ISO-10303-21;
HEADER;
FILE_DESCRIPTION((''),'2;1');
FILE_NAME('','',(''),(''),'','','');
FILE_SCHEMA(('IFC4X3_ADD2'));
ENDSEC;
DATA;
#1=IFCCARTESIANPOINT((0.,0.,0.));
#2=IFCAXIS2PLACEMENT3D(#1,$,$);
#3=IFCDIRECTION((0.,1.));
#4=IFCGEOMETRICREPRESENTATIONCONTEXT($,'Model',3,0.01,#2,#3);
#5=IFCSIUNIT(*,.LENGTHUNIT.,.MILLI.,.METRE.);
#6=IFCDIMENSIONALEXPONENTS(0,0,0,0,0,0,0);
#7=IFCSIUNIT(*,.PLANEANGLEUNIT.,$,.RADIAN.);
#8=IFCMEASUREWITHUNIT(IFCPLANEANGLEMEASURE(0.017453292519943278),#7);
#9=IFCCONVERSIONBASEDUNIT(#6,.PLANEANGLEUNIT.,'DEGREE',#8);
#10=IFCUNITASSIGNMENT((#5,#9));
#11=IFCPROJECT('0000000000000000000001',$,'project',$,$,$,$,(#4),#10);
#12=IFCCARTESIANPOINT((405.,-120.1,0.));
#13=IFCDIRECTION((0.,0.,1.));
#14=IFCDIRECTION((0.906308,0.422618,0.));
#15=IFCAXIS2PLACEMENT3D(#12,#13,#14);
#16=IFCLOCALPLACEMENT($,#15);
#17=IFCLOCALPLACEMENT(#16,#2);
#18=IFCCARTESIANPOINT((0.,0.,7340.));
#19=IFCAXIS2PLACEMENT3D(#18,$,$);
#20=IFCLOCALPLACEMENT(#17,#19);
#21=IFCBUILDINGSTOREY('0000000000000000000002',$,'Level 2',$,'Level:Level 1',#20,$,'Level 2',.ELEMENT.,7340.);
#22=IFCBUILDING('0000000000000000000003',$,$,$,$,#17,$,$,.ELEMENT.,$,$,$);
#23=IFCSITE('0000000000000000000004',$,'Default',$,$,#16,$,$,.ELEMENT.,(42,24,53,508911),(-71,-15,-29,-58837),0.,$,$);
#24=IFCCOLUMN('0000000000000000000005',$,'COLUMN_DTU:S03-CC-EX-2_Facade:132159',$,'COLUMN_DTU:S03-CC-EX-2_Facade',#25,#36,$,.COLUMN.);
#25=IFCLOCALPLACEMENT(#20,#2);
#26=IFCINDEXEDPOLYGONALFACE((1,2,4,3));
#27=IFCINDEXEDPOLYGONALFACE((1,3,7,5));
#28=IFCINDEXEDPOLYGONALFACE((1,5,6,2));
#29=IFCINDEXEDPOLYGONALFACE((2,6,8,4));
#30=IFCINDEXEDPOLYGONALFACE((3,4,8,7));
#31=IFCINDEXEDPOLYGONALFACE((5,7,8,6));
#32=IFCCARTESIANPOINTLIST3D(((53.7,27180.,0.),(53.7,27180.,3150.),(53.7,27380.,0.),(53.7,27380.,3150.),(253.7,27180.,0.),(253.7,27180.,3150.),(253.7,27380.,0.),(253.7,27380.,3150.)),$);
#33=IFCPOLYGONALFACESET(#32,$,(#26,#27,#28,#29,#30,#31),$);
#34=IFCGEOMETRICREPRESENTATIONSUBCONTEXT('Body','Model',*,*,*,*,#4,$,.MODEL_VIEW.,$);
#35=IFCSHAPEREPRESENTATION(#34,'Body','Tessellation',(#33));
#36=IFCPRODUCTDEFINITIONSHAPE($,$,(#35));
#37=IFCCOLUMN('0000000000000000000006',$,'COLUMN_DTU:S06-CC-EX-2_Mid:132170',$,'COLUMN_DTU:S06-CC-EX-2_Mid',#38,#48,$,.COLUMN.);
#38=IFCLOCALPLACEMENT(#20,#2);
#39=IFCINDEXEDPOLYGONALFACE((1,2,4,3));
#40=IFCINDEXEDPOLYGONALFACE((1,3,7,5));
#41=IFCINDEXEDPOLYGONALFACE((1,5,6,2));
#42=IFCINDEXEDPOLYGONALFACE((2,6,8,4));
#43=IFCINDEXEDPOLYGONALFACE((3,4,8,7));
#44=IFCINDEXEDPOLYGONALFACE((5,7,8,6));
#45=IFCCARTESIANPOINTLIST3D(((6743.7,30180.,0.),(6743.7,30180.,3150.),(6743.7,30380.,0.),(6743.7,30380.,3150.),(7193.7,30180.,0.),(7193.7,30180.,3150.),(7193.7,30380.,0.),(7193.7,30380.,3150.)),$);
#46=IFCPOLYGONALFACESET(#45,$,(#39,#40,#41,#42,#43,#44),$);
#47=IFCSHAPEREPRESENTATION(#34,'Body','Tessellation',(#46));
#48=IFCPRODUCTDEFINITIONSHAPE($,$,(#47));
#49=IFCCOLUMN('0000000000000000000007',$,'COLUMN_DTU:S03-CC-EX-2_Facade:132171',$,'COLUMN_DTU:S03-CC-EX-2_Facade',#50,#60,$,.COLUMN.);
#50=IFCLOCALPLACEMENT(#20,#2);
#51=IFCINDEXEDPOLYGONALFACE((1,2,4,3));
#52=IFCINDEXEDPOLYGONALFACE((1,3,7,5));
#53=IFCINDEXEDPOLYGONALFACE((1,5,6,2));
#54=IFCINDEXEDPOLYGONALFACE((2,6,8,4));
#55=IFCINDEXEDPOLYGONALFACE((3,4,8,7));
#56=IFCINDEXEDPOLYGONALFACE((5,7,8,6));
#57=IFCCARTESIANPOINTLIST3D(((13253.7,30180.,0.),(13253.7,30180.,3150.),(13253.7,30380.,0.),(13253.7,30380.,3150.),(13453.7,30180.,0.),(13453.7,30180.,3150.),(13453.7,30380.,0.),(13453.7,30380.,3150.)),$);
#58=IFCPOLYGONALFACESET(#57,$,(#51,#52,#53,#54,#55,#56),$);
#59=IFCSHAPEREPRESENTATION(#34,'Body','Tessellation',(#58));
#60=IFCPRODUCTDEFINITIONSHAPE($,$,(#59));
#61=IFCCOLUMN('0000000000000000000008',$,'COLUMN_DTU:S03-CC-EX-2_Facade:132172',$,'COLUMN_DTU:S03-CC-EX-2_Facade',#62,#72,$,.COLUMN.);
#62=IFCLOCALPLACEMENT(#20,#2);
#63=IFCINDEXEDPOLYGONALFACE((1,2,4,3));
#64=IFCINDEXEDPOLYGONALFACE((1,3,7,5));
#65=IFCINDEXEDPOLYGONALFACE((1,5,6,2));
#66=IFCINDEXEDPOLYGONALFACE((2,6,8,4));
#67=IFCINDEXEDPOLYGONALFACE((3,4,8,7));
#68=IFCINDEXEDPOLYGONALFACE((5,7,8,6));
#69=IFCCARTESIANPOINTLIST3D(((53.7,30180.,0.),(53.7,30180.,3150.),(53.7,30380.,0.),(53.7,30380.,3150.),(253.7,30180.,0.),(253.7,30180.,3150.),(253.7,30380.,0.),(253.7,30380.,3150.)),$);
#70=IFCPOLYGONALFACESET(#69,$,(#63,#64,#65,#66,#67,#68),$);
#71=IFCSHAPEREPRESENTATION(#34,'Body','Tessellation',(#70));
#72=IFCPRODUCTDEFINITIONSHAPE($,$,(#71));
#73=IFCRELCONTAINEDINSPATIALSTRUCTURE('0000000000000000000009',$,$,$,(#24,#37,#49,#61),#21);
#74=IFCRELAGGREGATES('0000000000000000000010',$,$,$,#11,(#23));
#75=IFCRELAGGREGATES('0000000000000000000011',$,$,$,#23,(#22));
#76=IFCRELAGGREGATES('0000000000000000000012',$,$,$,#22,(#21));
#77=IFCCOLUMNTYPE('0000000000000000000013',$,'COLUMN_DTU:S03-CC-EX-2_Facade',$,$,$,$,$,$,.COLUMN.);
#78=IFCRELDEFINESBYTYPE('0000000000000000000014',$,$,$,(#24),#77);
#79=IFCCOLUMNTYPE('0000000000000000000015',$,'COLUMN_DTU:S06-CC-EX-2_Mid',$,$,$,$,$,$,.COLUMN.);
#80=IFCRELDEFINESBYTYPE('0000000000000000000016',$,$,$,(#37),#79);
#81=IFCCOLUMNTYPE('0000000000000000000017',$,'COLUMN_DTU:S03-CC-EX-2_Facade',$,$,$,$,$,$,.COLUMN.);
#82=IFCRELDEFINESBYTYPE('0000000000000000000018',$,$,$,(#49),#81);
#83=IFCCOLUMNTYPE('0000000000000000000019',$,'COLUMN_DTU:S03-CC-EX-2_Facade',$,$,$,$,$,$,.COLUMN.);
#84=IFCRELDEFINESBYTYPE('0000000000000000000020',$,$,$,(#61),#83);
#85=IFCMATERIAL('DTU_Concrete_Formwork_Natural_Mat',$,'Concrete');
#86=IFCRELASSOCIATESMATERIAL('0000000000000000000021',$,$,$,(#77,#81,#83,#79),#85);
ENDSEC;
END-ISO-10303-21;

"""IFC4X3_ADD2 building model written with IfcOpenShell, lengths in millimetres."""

from ifc_helpers import new_model, entity, si_unit, converted_unit, direction, frame, frame_2d, origin, origin_2d_with_axis, place, context, subcontext, project, spatial, rectangle, extrude, source, transform, mapped, material, material_profile, profile_set, type_object, type_shapes, element, save


model = new_model("IFC4X3_ADD2")

# Units and contexts
model_context = context("Model", 3, precision=0.01, world=origin(), true_north=direction((0.0, 1.0)))
body_context = subcontext(model_context, "Body", "Model", "MODEL_VIEW")
ifc_project = project(units=[si_unit("LENGTHUNIT", "METRE", prefix="MILLI"), converted_unit("PLANEANGLEUNIT", "DEGREE", entity("IfcPlaneAngleMeasure", 0.017453292519943278), si_unit("PLANEANGLEUNIT", "RADIAN"), dimensions=[0, 0, 0, 0, 0, 0, 0])], contexts=[model_context])

# Site, building, storey
site_placement = place(None, frame((405.0, -120.1, 0.0), z_axis=(0.0, 0.0, 1.0), x_axis=(0.906308, 0.422618, 0.0)))
site = spatial("IfcSite", under=ifc_project, at=site_placement, Name="Default", CompositionType="ELEMENT", RefLatitude=(42, 24, 53, 508911), RefLongitude=(-71, -15, -29, -58837), RefElevation=0.0)
building_placement = place(site_placement, origin())
building = spatial("IfcBuilding", under=site, at=building_placement, CompositionType="ELEMENT")
storey_placement = place(building_placement, frame((0.0, 0.0, 7340.0)))
storey = spatial("IfcBuildingStorey", under=building, at=storey_placement, Name="Level 2", ObjectType="Level:Level 1", LongName="Level 2", CompositionType="ELEMENT", Elevation=7340.0)

# Columns
ifc_material = material(Name="DTU_Concrete_Formwork_Natural_Mat", Category="Concrete")
ifc_material_profile_1 = material_profile(ifc_material, rectangle(XDim=200.0, YDim=200.0, at=frame_2d((0.0, 0.0), x_axis=(1.0, 0.0))), Name="S03-CC-EX-2_Facade")
ifc_profile_set_1 = profile_set([ifc_material_profile_1], Name="S03-CC-EX-2_Facade")
ifc_material_profile_2 = material_profile(ifc_material, rectangle(XDim=200.0, YDim=450.0, at=origin_2d_with_axis()), Name="S06-CC-EX-2_Mid")
ifc_profile_set_2 = profile_set([ifc_material_profile_2], Name="S06-CC-EX-2_Mid")
column_type_1 = type_object("IfcColumnType", Name="COLUMN_DTU:S03-CC-EX-2_Facade", PredefinedType="COLUMN", material=ifc_profile_set_1)
shared_shape_1 = source(origin(), body_context, "Body", "SweptSolid", [
    extrude(rectangle(XDim=200.0, YDim=200.0, at=frame_2d((0.0, 0.0), x_axis=(1.0, 0.0))), frame((153.7, 27280.0, 7340.0), z_axis=(0.0, 0.0, 1.0), x_axis=(0.0, -1.0, 0.0)), (0.0, 0.0, 1.0), 3150.0),
])
type_shapes(column_type_1, [shared_shape_1])
column_1_placement = place(storey_placement, frame((0.0, 0.0, -7340.0)))
element("IfcColumn", 1, at=column_1_placement, inside=storey, type_object=column_type_1, Name="COLUMN_DTU:S03-CC-EX-2_Facade:132159", ObjectType="COLUMN_DTU:S03-CC-EX-2_Facade", PredefinedType="COLUMN", context=body_context, shape_type="MappedRepresentation", body=[
    mapped(shared_shape_1, transform((0.0, 0.0, 0.0), scale=1.0)),
])
column_type_2 = type_object("IfcColumnType", Name="COLUMN_DTU:S06-CC-EX-2_Mid", PredefinedType="COLUMN", material=ifc_profile_set_2)
shared_shape_2 = source(origin(), body_context, "Body", "SweptSolid", [
    extrude(rectangle(XDim=200.0, YDim=450.0, at=frame_2d((0.0, 0.0), x_axis=(1.0, 0.0))), frame((6968.7, 30280.0, 7340.0), z_axis=(0.0, 0.0, 1.0), x_axis=(0.0, 1.0, 0.0)), (0.0, 0.0, 1.0), 3150.0),
])
type_shapes(column_type_2, [shared_shape_2])
column_2_placement = place(storey_placement, frame((0.0, 0.0, -7340.0)))
element("IfcColumn", 2, at=column_2_placement, inside=storey, type_object=column_type_2, Name="COLUMN_DTU:S06-CC-EX-2_Mid:132170", ObjectType="COLUMN_DTU:S06-CC-EX-2_Mid", PredefinedType="COLUMN", context=body_context, shape_type="MappedRepresentation", body=[
    mapped(shared_shape_2, transform((0.0, 0.0, 0.0), scale=1.0)),
])
column_type_3 = type_object("IfcColumnType", Name="COLUMN_DTU:S03-CC-EX-2_Facade", PredefinedType="COLUMN", material=ifc_profile_set_1)
shared_shape_3 = source(origin(), body_context, "Body", "SweptSolid", [
    extrude(rectangle(XDim=200.0, YDim=200.0, at=frame_2d((0.0, 0.0), x_axis=(1.0, 0.0))), frame((13353.7, 30280.0, 7340.0), z_axis=(0.0, 0.0, 1.0), x_axis=(0.0, -1.0, 0.0)), (0.0, 0.0, 1.0), 3150.0),
])
type_shapes(column_type_3, [shared_shape_3])
column_3_placement = place(storey_placement, frame((0.0, 0.0, -7340.0)))
element("IfcColumn", 3, at=column_3_placement, inside=storey, type_object=column_type_3, Name="COLUMN_DTU:S03-CC-EX-2_Facade:132171", ObjectType="COLUMN_DTU:S03-CC-EX-2_Facade", PredefinedType="COLUMN", context=body_context, shape_type="MappedRepresentation", body=[
    mapped(shared_shape_3, transform((0.0, 0.0, 0.0), scale=1.0)),
])
column_type_4 = type_object("IfcColumnType", Name="COLUMN_DTU:S03-CC-EX-2_Facade", PredefinedType="COLUMN", material=ifc_profile_set_1)
shared_shape_4 = source(origin(), body_context, "Body", "SweptSolid", [
    extrude(rectangle(XDim=200.0, YDim=200.0, at=frame_2d((0.0, 0.0), x_axis=(1.0, 0.0))), frame((153.7, 30280.0, 7340.0), z_axis=(0.0, 0.0, 1.0), x_axis=(0.0, -1.0, 0.0)), (0.0, 0.0, 1.0), 3150.0),
])
type_shapes(column_type_4, [shared_shape_4])
column_4_placement = place(storey_placement, frame((0.0, 0.0, -7340.0)))
element("IfcColumn", 4, at=column_4_placement, inside=storey, type_object=column_type_4, Name="COLUMN_DTU:S03-CC-EX-2_Facade:132172", ObjectType="COLUMN_DTU:S03-CC-EX-2_Facade", PredefinedType="COLUMN", context=body_context, shape_type="MappedRepresentation", body=[
    mapped(shared_shape_4, transform((0.0, 0.0, 0.0), scale=1.0)),
])

save(model, "model.ifc")
